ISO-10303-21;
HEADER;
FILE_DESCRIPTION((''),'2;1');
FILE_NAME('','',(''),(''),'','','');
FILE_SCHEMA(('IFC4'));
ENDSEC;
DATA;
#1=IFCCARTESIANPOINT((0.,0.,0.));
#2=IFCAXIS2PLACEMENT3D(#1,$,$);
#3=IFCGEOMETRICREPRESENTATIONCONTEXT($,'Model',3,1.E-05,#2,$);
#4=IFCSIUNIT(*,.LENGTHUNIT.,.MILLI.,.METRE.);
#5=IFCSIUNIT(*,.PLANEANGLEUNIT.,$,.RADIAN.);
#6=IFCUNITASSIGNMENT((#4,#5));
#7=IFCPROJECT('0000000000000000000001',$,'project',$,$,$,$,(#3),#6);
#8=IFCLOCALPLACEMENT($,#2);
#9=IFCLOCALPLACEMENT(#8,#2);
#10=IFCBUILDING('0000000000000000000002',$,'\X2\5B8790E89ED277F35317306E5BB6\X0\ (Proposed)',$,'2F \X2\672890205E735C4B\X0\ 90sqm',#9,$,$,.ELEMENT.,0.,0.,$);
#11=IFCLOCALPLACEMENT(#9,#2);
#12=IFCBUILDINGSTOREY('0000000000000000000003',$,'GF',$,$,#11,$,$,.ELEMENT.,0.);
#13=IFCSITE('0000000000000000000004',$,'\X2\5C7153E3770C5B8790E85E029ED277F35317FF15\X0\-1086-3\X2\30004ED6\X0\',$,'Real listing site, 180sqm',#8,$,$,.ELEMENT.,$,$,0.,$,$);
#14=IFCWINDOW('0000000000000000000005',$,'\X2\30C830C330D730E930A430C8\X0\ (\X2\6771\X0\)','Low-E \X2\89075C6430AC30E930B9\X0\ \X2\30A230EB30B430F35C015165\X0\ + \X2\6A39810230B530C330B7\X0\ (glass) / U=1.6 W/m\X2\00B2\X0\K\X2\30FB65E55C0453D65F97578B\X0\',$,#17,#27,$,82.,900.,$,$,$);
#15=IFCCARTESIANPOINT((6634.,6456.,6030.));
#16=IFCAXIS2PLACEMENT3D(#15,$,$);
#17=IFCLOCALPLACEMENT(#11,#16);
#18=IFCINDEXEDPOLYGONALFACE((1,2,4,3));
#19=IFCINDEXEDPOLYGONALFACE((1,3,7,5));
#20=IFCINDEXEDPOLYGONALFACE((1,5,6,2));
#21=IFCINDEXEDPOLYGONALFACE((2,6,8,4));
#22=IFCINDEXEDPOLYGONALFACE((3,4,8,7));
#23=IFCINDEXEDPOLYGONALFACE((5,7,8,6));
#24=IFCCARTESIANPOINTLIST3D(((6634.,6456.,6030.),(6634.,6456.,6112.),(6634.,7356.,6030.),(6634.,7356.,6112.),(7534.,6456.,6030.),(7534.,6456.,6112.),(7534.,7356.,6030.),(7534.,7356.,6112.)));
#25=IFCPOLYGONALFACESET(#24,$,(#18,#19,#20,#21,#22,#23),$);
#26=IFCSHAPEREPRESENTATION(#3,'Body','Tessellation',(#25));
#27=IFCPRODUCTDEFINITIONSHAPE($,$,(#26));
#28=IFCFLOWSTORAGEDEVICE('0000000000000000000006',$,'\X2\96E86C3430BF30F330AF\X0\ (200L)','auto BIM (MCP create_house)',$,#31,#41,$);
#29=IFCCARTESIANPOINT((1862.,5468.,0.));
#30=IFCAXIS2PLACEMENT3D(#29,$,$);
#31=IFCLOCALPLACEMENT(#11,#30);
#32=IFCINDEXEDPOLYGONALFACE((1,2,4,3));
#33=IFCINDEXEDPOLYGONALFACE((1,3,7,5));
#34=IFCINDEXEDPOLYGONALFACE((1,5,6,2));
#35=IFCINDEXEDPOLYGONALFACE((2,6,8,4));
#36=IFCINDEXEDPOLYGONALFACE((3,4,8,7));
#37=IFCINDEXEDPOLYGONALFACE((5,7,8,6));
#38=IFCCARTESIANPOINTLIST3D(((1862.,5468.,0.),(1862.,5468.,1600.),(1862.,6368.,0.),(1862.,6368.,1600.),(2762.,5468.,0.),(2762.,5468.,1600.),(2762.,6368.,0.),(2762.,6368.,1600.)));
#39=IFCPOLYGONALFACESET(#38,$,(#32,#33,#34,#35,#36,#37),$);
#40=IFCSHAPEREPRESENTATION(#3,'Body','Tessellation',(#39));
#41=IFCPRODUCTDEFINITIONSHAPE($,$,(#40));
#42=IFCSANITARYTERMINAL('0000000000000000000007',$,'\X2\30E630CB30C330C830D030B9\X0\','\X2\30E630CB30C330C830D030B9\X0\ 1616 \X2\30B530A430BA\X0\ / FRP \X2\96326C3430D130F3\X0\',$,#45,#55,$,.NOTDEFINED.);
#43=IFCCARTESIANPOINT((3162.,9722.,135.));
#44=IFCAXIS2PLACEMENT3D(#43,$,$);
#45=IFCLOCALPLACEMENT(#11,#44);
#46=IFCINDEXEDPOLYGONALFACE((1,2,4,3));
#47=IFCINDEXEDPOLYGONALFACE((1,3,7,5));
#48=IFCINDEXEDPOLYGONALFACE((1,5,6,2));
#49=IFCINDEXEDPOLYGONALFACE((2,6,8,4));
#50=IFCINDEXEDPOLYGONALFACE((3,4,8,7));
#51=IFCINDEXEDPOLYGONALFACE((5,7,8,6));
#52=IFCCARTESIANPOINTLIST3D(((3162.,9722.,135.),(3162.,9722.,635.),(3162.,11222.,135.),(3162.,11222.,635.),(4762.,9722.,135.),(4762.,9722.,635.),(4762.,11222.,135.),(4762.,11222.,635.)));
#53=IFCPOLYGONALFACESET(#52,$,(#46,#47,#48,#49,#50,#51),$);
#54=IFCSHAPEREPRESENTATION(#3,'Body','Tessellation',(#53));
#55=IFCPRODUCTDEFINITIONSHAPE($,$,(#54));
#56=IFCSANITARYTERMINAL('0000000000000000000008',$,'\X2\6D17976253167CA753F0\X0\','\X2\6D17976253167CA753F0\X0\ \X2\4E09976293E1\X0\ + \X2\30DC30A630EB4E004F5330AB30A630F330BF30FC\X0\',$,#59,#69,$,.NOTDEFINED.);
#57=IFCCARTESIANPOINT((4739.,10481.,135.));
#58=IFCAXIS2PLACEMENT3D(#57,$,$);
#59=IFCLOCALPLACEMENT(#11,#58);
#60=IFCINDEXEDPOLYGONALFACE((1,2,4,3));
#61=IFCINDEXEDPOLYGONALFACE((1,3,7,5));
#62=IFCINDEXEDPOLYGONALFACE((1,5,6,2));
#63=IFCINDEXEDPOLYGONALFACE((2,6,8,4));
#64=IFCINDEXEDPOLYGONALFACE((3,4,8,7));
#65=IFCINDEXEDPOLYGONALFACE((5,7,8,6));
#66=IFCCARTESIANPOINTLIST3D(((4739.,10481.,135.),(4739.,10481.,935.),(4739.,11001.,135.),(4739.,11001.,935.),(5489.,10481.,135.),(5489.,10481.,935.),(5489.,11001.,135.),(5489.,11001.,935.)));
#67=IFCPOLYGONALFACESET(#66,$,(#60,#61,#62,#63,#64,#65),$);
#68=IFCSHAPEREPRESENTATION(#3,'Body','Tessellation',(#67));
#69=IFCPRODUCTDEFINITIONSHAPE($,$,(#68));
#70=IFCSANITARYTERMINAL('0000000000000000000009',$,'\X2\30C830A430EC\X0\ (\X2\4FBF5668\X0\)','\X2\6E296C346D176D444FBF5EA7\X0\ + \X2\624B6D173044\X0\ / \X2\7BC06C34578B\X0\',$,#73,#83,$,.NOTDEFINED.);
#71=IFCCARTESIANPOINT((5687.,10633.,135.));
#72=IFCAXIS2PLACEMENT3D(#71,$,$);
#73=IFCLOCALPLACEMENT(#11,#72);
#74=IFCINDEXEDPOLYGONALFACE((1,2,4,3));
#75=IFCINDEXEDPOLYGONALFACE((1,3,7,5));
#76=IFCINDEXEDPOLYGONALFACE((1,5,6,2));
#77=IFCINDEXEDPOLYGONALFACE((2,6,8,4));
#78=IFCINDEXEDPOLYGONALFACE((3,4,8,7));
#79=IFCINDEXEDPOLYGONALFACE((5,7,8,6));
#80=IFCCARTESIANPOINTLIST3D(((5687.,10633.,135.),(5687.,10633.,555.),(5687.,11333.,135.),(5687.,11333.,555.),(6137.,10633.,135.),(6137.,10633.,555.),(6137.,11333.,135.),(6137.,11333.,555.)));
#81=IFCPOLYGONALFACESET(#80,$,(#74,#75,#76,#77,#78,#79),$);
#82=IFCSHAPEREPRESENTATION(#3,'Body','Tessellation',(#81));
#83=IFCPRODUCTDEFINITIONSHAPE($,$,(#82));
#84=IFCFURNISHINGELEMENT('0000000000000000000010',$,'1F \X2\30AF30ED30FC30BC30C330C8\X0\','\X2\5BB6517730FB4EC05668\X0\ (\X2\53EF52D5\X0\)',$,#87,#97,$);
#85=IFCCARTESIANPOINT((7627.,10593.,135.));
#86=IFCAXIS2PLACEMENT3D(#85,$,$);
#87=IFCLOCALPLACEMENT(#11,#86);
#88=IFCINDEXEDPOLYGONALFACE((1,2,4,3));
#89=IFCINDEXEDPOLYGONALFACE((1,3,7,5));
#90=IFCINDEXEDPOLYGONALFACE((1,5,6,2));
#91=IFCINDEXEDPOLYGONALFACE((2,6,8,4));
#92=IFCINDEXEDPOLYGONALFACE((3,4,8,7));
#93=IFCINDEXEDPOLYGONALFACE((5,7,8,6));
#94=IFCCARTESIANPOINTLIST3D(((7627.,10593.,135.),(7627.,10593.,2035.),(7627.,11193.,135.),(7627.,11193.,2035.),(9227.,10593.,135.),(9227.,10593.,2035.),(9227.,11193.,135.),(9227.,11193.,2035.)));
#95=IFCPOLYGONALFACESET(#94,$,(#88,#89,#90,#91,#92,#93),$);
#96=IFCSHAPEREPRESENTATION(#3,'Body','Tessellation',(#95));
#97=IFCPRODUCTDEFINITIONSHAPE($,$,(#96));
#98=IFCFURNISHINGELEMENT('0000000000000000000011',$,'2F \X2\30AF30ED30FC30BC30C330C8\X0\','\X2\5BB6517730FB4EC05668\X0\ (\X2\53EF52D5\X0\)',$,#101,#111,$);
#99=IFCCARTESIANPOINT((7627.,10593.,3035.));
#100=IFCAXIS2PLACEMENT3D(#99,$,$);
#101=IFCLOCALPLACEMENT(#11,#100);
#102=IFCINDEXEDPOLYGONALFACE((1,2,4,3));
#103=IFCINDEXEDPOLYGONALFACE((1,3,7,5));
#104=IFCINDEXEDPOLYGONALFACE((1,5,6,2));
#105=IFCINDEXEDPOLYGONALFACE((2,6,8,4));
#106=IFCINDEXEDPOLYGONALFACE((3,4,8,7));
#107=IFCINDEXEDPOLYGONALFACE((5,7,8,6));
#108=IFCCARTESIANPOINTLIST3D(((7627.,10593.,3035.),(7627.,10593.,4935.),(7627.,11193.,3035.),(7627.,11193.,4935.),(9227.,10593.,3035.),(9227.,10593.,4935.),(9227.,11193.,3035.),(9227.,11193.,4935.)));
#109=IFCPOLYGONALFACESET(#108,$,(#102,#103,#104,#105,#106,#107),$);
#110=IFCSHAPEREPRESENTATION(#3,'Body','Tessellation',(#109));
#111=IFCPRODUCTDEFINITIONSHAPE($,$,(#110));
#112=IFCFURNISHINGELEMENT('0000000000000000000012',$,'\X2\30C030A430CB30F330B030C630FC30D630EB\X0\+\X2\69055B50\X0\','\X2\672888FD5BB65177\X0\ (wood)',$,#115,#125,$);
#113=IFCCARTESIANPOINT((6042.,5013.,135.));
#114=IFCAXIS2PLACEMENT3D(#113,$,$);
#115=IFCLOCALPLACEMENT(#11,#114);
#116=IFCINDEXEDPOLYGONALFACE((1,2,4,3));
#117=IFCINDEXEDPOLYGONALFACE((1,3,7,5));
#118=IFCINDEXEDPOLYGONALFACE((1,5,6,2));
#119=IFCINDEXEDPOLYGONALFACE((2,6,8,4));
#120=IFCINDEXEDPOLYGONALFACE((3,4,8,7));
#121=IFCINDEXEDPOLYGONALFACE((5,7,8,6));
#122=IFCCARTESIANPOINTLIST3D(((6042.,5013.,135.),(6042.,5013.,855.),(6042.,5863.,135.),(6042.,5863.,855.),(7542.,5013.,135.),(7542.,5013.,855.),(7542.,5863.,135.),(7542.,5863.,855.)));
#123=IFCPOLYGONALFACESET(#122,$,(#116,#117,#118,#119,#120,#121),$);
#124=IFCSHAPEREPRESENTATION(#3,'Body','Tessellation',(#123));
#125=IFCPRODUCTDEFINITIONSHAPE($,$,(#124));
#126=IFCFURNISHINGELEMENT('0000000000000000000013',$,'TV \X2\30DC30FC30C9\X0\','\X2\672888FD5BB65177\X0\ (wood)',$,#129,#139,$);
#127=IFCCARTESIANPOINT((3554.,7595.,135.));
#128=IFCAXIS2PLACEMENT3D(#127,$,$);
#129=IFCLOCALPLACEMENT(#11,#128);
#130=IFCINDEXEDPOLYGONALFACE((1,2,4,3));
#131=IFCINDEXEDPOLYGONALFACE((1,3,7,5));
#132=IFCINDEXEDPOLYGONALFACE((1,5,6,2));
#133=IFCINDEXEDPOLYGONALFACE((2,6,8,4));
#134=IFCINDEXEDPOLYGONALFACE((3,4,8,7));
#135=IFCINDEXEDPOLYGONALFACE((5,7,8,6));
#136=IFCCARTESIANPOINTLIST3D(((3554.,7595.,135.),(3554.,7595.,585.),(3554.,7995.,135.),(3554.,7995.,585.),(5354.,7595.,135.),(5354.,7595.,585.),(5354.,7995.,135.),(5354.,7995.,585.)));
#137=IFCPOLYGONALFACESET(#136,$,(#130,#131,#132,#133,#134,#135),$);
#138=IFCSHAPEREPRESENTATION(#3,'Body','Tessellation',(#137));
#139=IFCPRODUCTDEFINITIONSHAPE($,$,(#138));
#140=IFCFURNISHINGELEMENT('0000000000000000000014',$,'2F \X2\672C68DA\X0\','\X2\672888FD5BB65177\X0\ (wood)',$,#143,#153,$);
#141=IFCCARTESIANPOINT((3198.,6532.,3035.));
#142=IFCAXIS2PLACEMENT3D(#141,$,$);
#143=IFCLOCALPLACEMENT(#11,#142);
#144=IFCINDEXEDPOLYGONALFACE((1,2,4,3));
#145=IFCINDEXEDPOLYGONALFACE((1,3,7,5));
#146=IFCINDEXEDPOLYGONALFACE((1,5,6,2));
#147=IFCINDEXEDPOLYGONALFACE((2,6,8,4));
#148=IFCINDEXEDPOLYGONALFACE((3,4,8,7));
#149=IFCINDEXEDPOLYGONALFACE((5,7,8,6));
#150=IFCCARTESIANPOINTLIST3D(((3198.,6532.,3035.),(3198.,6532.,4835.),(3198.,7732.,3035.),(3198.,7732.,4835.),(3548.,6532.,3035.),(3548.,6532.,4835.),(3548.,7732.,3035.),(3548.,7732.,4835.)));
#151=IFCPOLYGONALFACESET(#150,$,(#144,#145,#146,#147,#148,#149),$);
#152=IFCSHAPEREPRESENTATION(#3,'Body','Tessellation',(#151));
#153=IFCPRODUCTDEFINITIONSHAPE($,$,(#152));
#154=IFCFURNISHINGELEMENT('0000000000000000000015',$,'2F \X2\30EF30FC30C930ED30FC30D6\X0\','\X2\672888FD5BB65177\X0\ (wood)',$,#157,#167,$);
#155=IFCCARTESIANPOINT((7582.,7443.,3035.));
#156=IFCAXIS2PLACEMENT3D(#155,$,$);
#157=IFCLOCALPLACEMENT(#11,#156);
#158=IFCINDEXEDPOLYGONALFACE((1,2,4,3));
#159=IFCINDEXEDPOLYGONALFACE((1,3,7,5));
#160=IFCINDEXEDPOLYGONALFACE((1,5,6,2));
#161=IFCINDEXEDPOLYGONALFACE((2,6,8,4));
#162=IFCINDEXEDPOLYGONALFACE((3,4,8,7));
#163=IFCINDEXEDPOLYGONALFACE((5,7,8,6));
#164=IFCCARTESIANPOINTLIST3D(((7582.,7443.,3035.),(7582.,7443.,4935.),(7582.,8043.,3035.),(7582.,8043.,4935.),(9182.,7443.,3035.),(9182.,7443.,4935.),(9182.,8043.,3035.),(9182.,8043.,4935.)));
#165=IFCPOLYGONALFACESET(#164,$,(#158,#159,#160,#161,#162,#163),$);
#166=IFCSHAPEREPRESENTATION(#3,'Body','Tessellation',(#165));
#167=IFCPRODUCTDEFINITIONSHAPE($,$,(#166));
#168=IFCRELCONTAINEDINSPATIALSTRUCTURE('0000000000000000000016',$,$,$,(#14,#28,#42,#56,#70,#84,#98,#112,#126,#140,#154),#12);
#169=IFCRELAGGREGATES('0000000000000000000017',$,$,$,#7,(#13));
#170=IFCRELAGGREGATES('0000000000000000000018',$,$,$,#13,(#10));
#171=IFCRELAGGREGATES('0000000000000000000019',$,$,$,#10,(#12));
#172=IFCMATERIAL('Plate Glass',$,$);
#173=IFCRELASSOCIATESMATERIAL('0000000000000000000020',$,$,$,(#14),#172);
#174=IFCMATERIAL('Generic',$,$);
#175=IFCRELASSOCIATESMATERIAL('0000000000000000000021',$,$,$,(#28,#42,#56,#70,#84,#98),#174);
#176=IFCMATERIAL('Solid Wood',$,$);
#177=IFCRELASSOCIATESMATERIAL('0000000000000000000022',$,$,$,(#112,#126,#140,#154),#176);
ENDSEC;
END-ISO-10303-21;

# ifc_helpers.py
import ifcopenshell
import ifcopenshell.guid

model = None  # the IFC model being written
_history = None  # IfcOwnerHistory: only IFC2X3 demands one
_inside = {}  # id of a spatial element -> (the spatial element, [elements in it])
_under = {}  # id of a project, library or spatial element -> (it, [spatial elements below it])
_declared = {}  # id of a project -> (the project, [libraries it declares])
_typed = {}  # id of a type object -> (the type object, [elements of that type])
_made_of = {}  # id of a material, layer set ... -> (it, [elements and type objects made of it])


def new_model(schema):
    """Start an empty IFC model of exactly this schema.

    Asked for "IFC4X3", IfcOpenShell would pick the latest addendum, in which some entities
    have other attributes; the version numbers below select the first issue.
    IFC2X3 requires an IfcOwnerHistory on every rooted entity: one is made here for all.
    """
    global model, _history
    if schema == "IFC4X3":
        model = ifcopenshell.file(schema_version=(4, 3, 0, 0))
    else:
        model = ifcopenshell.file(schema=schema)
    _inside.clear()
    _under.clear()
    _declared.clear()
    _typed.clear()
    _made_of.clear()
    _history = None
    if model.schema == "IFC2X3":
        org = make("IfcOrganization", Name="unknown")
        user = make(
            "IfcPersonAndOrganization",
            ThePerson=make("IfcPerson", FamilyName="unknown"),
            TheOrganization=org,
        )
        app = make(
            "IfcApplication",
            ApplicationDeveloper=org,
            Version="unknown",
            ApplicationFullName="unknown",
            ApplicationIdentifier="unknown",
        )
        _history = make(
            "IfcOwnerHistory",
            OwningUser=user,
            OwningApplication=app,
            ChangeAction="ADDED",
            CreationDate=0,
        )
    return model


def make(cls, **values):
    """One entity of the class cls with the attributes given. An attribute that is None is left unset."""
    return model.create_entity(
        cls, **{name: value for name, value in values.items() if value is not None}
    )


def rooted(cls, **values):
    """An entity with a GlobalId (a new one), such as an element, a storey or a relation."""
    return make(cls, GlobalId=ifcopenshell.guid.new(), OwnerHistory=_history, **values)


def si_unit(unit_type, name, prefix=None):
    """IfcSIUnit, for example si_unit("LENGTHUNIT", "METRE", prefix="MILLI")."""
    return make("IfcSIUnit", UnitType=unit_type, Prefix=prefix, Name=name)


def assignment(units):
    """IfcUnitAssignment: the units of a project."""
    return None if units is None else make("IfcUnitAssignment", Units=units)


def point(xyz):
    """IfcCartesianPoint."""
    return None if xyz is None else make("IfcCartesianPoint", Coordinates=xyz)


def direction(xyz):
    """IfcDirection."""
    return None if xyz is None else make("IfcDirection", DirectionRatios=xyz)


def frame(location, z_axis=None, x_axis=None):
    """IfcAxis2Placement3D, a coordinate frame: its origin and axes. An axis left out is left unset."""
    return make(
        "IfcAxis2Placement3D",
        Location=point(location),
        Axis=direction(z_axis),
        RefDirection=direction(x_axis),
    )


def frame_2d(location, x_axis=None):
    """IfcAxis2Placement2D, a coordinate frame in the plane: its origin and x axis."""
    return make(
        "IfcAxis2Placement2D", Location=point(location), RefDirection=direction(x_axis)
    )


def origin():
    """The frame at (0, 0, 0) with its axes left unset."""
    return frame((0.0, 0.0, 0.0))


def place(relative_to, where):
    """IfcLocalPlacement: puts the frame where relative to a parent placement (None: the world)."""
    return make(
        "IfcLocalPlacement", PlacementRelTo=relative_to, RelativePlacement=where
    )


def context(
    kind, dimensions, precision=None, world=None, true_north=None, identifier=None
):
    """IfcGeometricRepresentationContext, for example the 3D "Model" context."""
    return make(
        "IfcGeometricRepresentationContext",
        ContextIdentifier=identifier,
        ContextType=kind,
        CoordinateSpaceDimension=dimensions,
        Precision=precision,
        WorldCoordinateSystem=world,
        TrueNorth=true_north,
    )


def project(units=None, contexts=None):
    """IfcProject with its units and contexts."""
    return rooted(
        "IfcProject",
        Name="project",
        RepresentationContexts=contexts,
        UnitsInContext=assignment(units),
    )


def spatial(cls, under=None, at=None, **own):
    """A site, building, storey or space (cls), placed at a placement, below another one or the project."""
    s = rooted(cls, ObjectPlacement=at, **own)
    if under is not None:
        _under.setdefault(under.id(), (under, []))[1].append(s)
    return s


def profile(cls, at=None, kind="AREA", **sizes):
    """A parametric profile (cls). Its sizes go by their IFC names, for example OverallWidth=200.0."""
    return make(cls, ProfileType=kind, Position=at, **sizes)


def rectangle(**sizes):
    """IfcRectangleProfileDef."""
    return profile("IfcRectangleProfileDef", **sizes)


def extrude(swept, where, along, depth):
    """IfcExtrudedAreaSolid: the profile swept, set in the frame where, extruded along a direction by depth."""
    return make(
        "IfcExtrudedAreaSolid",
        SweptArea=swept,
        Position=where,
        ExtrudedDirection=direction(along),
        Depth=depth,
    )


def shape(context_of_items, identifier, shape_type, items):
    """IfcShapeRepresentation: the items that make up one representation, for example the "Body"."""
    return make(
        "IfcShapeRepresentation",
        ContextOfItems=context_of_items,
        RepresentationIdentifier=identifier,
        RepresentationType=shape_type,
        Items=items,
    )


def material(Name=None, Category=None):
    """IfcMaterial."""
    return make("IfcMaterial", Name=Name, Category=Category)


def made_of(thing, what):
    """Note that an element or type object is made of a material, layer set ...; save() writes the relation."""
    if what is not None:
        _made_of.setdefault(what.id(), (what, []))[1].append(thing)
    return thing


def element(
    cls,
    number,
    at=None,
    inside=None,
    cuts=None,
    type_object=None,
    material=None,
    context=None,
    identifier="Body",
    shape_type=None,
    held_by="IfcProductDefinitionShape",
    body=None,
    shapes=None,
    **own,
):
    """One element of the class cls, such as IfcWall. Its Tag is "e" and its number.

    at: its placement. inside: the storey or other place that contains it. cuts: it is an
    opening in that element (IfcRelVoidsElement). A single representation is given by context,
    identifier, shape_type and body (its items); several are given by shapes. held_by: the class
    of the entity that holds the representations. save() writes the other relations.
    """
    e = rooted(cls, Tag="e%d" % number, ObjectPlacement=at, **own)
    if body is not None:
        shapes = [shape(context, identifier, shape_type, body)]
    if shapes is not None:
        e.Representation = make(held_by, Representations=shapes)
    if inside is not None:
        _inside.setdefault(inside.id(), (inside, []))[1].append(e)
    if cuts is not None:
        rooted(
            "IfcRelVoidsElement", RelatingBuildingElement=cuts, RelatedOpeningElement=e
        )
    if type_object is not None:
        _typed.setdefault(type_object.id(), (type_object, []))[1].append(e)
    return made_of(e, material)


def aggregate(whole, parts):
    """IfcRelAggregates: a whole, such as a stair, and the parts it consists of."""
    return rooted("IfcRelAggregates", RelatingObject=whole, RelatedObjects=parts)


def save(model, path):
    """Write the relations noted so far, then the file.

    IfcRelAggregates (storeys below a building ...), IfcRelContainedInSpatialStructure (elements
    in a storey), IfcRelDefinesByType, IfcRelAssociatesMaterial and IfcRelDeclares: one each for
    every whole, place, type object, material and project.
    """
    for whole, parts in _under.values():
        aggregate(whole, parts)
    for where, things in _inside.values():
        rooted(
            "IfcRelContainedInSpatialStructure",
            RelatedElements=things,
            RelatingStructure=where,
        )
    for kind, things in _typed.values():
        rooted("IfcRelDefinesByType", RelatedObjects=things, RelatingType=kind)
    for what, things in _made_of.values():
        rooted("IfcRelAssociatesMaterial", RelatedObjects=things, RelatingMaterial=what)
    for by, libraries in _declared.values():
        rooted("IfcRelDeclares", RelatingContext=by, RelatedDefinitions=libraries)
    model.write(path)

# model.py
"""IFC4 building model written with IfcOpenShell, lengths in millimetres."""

from ifc_helpers import new_model, si_unit, frame, frame_2d, origin, place, context, project, spatial, rectangle, extrude, material, element, save


model = new_model("IFC4")

# Units and contexts
model_context = context("Model", 3, precision=1e-05, world=origin())
ifc_project = project(units=[si_unit("LENGTHUNIT", "METRE", prefix="MILLI"), si_unit("PLANEANGLEUNIT", "RADIAN")], contexts=[model_context])

# Site, building, storey
site_placement = place(None, origin())
site = spatial("IfcSite", under=ifc_project, at=site_placement, Name="山口県宇部市黒石北５-1086-3　他", ObjectType="Real listing site, 180sqm", CompositionType="ELEMENT", RefElevation=0.0)
building_placement = place(site_placement, origin())
building = spatial("IfcBuilding", under=site, at=building_placement, Name="宇部黒石北の家 (Proposed)", ObjectType="2F 木造平屋 90sqm", CompositionType="ELEMENT", ElevationOfRefHeight=0.0, ElevationOfTerrain=0.0)
storey_placement = place(building_placement, origin())
storey = spatial("IfcBuildingStorey", under=building, at=storey_placement, Name="GF", CompositionType="ELEMENT", Elevation=0.0)

# Shared definitions
ifc_material_1 = material(Name="Solid Wood")
ifc_material_2 = material(Name="Plate Glass")

# Window
window_1_placement = place(storey_placement, frame((6634.0, 6456.0, 6030.0)))
element("IfcWindow", 1, at=window_1_placement, inside=storey, material=ifc_material_2, Name="トップライト (東)", Description="Low-E 複層ガラス アルゴン封入 + 樹脂サッシ (glass) / U=1.6 W/m²K・日射取得型", OverallHeight=82.0, OverallWidth=900.0, context=model_context, shape_type="SweptSolid", body=[
    extrude(rectangle(XDim=900.0, YDim=900.0, at=frame_2d((450.0, 450.0))), frame((6634.0, 6456.0, 6030.0)), (0.0, 0.0, 1.0), 82.0),
])

# Flow storage device
ifc_material_3 = material(Name="Generic")
flow_storage_device_placement = place(storey_placement, frame((1862.0, 5468.0, 0.0)))
element("IfcFlowStorageDevice", 2, at=flow_storage_device_placement, inside=storey, material=ifc_material_3, Name="雨水タンク (200L)", Description="auto BIM (MCP create_house)", context=model_context, shape_type="SweptSolid", body=[
    extrude(rectangle(XDim=900.0, YDim=900.0, at=frame_2d((450.0, 450.0))), frame((1862.0, 5468.0, 0.0)), (0.0, 0.0, 1.0), 1600.0),
])

# Sanitary terminals
sanitary_terminal_1_placement = place(storey_placement, frame((3162.0, 9722.0, 135.0)))
element("IfcSanitaryTerminal", 3, at=sanitary_terminal_1_placement, inside=storey, material=ifc_material_3, Name="ユニットバス", Description="ユニットバス 1616 サイズ / FRP 防水パン", PredefinedType="NOTDEFINED", context=model_context, shape_type="SweptSolid", body=[
    extrude(rectangle(XDim=1600.0, YDim=1500.0, at=frame_2d((800.0, 750.0))), frame((3162.0, 9722.0, 135.0)), (0.0, 0.0, 1.0), 500.0),
])
sanitary_terminal_2_placement = place(storey_placement, frame((4739.0, 10481.0, 135.0)))
element("IfcSanitaryTerminal", 4, at=sanitary_terminal_2_placement, inside=storey, material=ifc_material_3, Name="洗面化粧台", Description="洗面化粧台 三面鏡 + ボウル一体カウンター", PredefinedType="NOTDEFINED", context=model_context, shape_type="SweptSolid", body=[
    extrude(rectangle(XDim=750.0, YDim=520.0, at=frame_2d((375.0, 260.0))), frame((4739.0, 10481.0, 135.0)), (0.0, 0.0, 1.0), 800.0),
])
sanitary_terminal_3_placement = place(storey_placement, frame((5687.0, 10633.0, 135.0)))
element("IfcSanitaryTerminal", 5, at=sanitary_terminal_3_placement, inside=storey, material=ifc_material_3, Name="トイレ (便器)", Description="温水洗浄便座 + 手洗い / 節水型", PredefinedType="NOTDEFINED", context=model_context, shape_type="SweptSolid", body=[
    extrude(rectangle(XDim=450.0, YDim=700.0, at=frame_2d((225.0, 350.0))), frame((5687.0, 10633.0, 135.0)), (0.0, 0.0, 1.0), 420.0),
])

# Furnishing elements
furnishing_1_placement = place(storey_placement, frame((7627.0, 10593.0, 135.0)))
element("IfcFurnishingElement", 6, at=furnishing_1_placement, inside=storey, material=ifc_material_3, Name="1F クローゼット", Description="家具・什器 (可動)", context=model_context, shape_type="SweptSolid", body=[
    extrude(rectangle(XDim=1600.0, YDim=600.0, at=frame_2d((800.0, 300.0))), frame((7627.0, 10593.0, 135.0)), (0.0, 0.0, 1.0), 1900.0),
])
furnishing_2_placement = place(storey_placement, frame((7627.0, 10593.0, 3035.0)))
element("IfcFurnishingElement", 7, at=furnishing_2_placement, inside=storey, material=ifc_material_3, Name="2F クローゼット", Description="家具・什器 (可動)", context=model_context, shape_type="SweptSolid", body=[
    extrude(rectangle(XDim=1600.0, YDim=600.0, at=frame_2d((800.0, 300.0))), frame((7627.0, 10593.0, 3035.0)), (0.0, 0.0, 1.0), 1900.0),
])
furnishing_3_placement = place(storey_placement, frame((6042.0, 5013.0, 135.0)))
element("IfcFurnishingElement", 8, at=furnishing_3_placement, inside=storey, material=ifc_material_1, Name="ダイニングテーブル+椅子", Description="木製家具 (wood)", context=model_context, shape_type="SweptSolid", body=[
    extrude(rectangle(XDim=1500.0, YDim=850.0, at=frame_2d((750.0, 425.0))), frame((6042.0, 5013.0, 135.0)), (0.0, 0.0, 1.0), 720.0),
])
furnishing_4_placement = place(storey_placement, frame((3554.0, 7595.0, 135.0)))
element("IfcFurnishingElement", 9, at=furnishing_4_placement, inside=storey, material=ifc_material_1, Name="TV ボード", Description="木製家具 (wood)", context=model_context, shape_type="SweptSolid", body=[
    extrude(rectangle(XDim=1800.0, YDim=400.0, at=frame_2d((900.0, 200.0))), frame((3554.0, 7595.0, 135.0)), (0.0, 0.0, 1.0), 450.0),
])
furnishing_5_placement = place(storey_placement, frame((3198.0, 6532.0, 3035.0)))
element("IfcFurnishingElement", 10, at=furnishing_5_placement, inside=storey, material=ifc_material_1, Name="2F 本棚", Description="木製家具 (wood)", context=model_context, shape_type="SweptSolid", body=[
    extrude(rectangle(XDim=350.0, YDim=1200.0, at=frame_2d((175.0, 600.0))), frame((3198.0, 6532.0, 3035.0)), (0.0, 0.0, 1.0), 1800.0),
])
furnishing_6_placement = place(storey_placement, frame((7582.0, 7443.0, 3035.0)))
element("IfcFurnishingElement", 11, at=furnishing_6_placement, inside=storey, material=ifc_material_1, Name="2F ワードローブ", Description="木製家具 (wood)", context=model_context, shape_type="SweptSolid", body=[
    extrude(rectangle(XDim=1600.0, YDim=600.0, at=frame_2d((800.0, 300.0))), frame((7582.0, 7443.0, 3035.0)), (0.0, 0.0, 1.0), 1900.0),
])

save(model, "model.ifc")
